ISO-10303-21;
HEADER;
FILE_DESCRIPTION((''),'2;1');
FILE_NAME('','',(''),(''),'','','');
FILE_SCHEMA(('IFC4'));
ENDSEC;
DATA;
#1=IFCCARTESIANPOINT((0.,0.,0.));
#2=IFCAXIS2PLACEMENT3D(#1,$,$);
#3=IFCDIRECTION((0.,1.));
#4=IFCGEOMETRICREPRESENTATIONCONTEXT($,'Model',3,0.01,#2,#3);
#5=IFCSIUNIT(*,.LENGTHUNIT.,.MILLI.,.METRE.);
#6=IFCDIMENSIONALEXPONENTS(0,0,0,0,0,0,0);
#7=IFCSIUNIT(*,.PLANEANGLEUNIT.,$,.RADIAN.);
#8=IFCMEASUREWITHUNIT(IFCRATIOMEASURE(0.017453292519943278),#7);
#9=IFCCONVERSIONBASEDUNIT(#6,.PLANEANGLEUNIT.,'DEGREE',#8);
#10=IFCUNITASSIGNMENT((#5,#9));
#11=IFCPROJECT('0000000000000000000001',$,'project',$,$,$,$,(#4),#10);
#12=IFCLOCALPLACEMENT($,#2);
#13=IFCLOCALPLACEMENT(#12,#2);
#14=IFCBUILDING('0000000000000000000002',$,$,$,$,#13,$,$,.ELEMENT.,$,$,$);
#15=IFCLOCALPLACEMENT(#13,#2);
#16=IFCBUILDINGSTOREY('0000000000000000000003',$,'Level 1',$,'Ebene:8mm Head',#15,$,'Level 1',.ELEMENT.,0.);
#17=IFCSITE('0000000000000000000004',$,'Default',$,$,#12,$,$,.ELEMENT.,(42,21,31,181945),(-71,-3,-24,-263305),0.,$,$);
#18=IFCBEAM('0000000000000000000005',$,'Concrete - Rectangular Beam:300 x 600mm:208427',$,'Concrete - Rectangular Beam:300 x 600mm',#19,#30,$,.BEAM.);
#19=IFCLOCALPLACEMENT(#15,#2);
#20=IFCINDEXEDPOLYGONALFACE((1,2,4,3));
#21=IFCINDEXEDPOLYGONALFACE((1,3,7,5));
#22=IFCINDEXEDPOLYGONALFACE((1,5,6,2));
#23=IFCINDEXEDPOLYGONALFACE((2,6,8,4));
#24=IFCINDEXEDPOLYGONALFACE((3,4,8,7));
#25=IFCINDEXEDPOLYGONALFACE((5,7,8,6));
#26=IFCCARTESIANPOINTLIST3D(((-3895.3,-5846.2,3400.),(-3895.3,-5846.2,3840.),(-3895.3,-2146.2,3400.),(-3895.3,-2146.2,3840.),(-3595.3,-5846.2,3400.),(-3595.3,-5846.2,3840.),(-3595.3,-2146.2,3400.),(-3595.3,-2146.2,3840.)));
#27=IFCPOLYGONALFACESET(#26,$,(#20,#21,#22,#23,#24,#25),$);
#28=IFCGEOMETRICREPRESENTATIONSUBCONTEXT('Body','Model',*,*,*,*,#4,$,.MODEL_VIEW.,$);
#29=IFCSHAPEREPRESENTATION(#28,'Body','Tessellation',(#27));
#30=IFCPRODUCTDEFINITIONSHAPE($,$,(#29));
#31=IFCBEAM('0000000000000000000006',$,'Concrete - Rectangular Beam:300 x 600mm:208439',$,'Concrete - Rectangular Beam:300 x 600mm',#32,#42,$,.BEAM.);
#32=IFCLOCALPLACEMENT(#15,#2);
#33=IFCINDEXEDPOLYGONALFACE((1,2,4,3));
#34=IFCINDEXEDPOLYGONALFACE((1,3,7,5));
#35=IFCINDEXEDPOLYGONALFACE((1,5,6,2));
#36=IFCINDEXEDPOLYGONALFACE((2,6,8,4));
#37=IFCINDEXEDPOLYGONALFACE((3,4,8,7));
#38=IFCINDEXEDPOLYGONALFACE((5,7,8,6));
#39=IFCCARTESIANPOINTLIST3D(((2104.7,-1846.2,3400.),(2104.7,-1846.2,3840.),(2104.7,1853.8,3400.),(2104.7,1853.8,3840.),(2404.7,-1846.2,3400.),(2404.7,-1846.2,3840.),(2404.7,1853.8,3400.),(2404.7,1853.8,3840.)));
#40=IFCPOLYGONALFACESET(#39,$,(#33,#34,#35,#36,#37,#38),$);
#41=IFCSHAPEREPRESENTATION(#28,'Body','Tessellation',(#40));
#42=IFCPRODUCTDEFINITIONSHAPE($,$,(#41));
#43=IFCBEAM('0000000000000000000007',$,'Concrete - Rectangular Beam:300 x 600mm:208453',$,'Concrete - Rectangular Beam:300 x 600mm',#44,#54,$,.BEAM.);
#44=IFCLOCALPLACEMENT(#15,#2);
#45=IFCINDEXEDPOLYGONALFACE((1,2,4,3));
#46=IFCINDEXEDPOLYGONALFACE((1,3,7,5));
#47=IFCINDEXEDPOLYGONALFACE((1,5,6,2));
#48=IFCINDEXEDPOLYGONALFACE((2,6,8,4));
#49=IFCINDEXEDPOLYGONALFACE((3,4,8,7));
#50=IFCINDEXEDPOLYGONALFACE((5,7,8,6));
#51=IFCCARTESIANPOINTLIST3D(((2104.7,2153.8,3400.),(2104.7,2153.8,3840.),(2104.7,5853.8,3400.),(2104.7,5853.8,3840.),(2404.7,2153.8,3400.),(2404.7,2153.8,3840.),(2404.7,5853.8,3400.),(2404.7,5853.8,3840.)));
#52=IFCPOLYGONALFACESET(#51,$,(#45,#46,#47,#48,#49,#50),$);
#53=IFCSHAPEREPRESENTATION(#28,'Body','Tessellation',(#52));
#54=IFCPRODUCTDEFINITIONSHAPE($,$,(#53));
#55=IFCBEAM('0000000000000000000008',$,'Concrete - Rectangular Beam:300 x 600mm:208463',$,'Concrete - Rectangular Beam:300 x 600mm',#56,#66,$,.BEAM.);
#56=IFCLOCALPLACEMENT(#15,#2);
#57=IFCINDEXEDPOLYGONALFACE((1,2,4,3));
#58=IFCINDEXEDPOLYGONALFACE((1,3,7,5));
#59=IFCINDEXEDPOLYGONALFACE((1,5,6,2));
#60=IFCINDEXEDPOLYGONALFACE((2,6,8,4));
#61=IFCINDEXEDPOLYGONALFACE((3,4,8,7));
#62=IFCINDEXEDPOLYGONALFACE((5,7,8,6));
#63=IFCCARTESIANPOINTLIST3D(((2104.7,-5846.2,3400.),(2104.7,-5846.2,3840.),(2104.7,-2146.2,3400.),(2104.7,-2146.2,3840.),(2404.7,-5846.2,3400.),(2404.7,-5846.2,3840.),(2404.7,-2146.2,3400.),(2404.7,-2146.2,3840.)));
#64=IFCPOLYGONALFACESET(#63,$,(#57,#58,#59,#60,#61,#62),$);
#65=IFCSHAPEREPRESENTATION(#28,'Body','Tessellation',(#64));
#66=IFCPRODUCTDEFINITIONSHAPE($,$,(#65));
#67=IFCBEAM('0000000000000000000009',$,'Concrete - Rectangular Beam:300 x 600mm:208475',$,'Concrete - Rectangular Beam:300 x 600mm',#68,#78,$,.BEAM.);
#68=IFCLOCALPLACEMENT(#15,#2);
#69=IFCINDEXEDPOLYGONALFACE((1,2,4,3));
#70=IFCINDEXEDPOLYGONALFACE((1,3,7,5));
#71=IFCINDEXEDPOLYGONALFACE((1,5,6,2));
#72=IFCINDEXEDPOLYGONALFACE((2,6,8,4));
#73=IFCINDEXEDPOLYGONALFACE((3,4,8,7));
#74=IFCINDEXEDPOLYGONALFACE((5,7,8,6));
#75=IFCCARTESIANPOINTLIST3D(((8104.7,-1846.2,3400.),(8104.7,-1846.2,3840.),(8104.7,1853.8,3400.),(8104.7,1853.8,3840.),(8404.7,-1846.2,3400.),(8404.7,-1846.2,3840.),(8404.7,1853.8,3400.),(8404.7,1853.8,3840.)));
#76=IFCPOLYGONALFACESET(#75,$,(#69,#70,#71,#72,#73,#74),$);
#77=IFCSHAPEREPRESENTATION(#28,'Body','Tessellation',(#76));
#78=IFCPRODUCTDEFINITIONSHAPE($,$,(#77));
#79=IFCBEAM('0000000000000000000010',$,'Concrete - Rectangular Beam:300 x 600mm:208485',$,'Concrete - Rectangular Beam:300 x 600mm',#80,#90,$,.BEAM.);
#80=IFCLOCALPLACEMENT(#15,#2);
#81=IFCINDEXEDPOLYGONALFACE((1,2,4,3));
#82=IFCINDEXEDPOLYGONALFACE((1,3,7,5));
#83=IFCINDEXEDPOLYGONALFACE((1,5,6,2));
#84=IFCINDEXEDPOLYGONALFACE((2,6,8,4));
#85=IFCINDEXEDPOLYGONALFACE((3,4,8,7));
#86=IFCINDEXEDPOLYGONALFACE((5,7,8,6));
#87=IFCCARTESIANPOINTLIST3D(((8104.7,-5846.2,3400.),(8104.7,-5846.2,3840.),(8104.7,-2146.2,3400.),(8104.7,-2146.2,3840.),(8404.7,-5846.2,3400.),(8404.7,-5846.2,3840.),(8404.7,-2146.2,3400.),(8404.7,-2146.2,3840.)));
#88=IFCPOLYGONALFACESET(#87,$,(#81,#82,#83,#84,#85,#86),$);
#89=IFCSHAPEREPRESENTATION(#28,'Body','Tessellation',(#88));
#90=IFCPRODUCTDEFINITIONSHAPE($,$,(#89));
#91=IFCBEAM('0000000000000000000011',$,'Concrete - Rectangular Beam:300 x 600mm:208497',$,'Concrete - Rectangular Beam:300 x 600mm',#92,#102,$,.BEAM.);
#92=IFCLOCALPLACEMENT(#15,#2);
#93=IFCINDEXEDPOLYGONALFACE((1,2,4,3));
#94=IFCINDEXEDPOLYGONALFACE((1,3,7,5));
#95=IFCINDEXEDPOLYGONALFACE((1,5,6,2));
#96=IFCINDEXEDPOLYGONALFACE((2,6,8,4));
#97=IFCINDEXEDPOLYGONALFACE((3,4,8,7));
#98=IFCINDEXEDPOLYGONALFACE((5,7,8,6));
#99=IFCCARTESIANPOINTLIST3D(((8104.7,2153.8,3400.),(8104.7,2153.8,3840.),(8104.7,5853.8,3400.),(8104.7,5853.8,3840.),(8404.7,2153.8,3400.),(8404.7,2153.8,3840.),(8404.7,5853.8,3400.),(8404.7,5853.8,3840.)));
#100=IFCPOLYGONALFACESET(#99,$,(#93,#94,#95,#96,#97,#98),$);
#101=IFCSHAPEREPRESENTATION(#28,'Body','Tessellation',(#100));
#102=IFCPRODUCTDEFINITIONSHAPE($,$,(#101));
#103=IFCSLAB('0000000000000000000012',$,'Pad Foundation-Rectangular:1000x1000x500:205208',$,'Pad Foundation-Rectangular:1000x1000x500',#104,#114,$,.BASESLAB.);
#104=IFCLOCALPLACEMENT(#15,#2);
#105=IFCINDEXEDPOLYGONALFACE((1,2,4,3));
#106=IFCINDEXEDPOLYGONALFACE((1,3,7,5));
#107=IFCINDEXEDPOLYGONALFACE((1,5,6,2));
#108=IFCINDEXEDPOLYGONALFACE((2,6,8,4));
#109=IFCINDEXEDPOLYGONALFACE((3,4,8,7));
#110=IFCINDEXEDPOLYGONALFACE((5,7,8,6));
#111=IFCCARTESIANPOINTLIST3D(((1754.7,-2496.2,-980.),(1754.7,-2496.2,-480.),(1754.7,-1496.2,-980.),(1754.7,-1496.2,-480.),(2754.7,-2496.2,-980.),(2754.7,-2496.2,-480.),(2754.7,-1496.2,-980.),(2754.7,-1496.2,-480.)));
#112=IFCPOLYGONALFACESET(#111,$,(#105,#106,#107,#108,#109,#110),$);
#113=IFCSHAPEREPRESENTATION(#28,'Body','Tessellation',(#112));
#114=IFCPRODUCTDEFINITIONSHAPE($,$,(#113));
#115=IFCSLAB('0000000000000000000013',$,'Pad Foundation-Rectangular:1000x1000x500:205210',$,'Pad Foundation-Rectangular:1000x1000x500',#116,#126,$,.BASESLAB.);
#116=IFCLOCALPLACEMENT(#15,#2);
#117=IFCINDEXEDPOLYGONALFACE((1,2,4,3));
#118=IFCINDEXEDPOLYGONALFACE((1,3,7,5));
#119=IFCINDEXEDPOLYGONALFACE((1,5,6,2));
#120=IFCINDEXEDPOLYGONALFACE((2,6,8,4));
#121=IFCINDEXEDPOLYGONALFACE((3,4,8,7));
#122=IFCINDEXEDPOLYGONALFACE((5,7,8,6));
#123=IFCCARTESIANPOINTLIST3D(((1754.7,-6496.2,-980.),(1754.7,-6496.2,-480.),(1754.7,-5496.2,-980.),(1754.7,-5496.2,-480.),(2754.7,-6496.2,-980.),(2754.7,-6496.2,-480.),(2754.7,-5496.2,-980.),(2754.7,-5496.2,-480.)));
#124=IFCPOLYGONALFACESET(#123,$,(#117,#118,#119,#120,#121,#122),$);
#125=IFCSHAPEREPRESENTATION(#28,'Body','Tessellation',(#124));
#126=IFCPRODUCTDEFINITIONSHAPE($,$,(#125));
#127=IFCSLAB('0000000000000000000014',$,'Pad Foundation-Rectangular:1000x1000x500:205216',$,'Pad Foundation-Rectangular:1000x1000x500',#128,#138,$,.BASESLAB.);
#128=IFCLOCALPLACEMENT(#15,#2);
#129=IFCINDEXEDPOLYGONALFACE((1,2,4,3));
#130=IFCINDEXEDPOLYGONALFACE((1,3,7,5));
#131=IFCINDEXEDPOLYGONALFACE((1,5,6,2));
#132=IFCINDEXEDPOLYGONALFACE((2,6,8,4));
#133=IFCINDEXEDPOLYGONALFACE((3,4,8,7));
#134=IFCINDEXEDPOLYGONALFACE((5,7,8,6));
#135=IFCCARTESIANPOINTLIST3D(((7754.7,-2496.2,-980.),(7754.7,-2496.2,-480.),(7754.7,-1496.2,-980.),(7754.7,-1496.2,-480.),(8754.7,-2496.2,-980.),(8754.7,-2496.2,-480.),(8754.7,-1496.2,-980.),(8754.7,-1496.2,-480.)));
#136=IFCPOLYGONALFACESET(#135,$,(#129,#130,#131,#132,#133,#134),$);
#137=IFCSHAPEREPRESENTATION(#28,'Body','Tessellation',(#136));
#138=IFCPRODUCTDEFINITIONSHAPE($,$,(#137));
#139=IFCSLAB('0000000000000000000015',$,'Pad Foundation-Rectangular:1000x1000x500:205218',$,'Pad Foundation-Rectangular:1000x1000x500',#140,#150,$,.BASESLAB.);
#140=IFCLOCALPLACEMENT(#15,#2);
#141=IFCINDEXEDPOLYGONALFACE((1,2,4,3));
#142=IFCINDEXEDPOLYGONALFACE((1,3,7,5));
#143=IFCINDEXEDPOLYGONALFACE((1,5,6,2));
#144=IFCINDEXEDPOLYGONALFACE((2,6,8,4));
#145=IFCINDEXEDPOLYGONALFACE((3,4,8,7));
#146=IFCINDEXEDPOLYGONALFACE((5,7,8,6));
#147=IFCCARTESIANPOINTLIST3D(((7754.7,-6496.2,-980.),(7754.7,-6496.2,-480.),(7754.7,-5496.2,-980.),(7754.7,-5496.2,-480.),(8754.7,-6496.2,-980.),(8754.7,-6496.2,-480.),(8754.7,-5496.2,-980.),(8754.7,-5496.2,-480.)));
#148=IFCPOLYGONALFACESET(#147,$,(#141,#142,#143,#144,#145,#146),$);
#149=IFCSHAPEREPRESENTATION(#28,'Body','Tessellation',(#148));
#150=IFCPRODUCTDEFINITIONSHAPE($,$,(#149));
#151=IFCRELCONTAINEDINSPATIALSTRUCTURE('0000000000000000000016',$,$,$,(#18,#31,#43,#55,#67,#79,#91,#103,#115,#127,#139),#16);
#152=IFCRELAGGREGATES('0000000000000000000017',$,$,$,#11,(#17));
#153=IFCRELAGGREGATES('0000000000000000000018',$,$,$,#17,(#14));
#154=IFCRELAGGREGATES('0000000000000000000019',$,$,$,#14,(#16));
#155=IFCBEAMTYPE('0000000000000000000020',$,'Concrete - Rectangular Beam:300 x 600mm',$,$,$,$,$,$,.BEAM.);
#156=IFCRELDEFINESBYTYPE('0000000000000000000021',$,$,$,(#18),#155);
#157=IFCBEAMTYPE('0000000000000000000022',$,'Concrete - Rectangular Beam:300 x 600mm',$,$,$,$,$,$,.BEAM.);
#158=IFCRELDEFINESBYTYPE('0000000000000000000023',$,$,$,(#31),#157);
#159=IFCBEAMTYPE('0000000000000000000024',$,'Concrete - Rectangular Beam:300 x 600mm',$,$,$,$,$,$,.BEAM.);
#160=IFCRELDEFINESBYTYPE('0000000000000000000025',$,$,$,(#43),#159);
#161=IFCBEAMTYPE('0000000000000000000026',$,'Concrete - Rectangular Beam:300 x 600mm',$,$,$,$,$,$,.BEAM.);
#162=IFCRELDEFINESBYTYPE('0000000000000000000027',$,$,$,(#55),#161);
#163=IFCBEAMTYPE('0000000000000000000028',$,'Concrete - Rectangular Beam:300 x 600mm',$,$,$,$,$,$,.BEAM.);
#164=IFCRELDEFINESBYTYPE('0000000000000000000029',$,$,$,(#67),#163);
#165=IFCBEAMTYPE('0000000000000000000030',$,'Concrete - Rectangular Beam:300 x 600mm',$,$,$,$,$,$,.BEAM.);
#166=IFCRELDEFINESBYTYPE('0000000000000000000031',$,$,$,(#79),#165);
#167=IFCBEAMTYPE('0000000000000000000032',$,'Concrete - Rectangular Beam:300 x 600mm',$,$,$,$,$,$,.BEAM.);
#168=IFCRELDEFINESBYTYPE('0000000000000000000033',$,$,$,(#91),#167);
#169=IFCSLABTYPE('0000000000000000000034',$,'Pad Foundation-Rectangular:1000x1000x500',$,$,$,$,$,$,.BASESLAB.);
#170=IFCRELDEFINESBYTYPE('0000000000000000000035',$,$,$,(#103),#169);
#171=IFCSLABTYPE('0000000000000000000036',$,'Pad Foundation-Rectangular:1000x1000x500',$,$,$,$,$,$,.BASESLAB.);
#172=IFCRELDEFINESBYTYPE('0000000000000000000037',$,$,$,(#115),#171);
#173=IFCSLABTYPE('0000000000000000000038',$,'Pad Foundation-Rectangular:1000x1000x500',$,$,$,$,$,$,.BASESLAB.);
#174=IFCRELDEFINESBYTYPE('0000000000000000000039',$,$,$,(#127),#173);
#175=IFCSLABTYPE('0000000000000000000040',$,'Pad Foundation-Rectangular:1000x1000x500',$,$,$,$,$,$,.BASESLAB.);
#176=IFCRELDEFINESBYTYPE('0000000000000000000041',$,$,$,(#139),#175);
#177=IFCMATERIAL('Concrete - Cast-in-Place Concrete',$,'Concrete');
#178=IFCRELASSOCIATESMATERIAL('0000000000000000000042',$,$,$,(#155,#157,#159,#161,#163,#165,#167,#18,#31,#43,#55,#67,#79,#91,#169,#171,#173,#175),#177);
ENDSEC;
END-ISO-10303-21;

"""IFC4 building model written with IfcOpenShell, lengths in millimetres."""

from ifc_helpers import new_model, entity, si_unit, converted_unit, direction, frame, frame_2d, origin, origin_2d_with_axis, place, context, subcontext, project, spatial, polyline, segment, composite_curve, rectangle, outline, extrude, source, transform, mapped, material, material_profile, profile_set, profile_usage, type_object, type_shapes, element, save


model = new_model("IFC4")

# Units and contexts
model_context = context("Model", 3, precision=0.01, world=origin(), true_north=direction((0.0, 1.0)))
body_context = subcontext(model_context, "Body", "Model", "MODEL_VIEW")
ifc_project = project(units=[si_unit("LENGTHUNIT", "METRE", prefix="MILLI"), converted_unit("PLANEANGLEUNIT", "DEGREE", entity("IfcRatioMeasure", 0.017453292519943278), si_unit("PLANEANGLEUNIT", "RADIAN"), dimensions=[0, 0, 0, 0, 0, 0, 0])], contexts=[model_context])

# Site, building, storey
site_placement = place(None, origin())
site = spatial("IfcSite", under=ifc_project, at=site_placement, Name="Default", CompositionType="ELEMENT", RefLatitude=(42, 21, 31, 181945), RefLongitude=(-71, -3, -24, -263305), RefElevation=0.0)
building_placement = place(site_placement, origin())
building = spatial("IfcBuilding", under=site, at=building_placement, CompositionType="ELEMENT")
storey_placement = place(building_placement, origin())
storey = spatial("IfcBuildingStorey", under=building, at=storey_placement, Name="Level 1", ObjectType="Ebene:8mm Head", LongName="Level 1", CompositionType="ELEMENT", Elevation=0.0)

# Beams
ifc_material_1 = material(Name="Concrete - Cast-in-Place Concrete", Category="Concrete")
ifc_material_profile_1 = material_profile(ifc_material_1, outline(composite_curve([segment(polyline([(-150.0, -300.0, 0.0), (-150.0, 140.0, 0.0)]), True, "CONTINUOUS"), segment(polyline([(-150.0, 140.0, 0.0), (150.0, 140.0, 0.0)]), True, "CONTINUOUS"), segment(polyline([(150.0, 140.0, 0.0), (150.0, -300.0, 0.0)]), True, "CONTINUOUS"), segment(polyline([(150.0, -300.0, 0.0), (-150.0, -300.0, 0.0)]), True, "CONTINUOUS")], self_intersect=False), kind="CURVE"), Name="300 x 600mm")
ifc_material_profile_2 = material_profile(ifc_material_1, outline(composite_curve([segment(polyline([(1850.0, -150.0, -300.0), (1850.0, -150.0, 300.0)]), True, "CONTINUOUS"), segment(polyline([(1850.0, -150.0, 300.0), (-1850.0, -150.0, 300.0)]), True, "CONTINUOUS"), segment(polyline([(-1850.0, -150.0, 300.0), (-1850.0, -150.0, -300.0)]), True, "CONTINUOUS"), segment(polyline([(-1850.0, -150.0, -300.0), (1850.0, -150.0, -300.0)]), True, "CONTINUOUS")], self_intersect=False), kind="CURVE"), Name="300 x 600mm")
ifc_profile_set = profile_set([ifc_material_profile_1, ifc_material_profile_2], Name="300 x 600mm")
ifc_profile_usage_1 = profile_usage(ifc_profile_set, cardinal=8)
beam_type_1 = type_object("IfcBeamType", Name="Concrete - Rectangular Beam:300 x 600mm", PredefinedType="BEAM", material=ifc_profile_set)
shared_shape_1 = source(origin(), body_context, "Body", "SweptSolid", [
    extrude(rectangle(XDim=440.0, YDim=300.0, at=frame_2d((0.0, 0.0), x_axis=(0.0, 1.0))), frame((-3745.3, -2146.2, 3620.0), z_axis=(0.0, -1.0, 0.0), x_axis=(-1.0, 0.0, 0.0)), (0.0, 0.0, 1.0), 3700.0),
])
type_shapes(beam_type_1, [shared_shape_1])
beam_1_placement = place(storey_placement, origin())
element("IfcBeam", 1, at=beam_1_placement, inside=storey, type_object=beam_type_1, material=ifc_profile_usage_1, Name="Concrete - Rectangular Beam:300 x 600mm:208427", ObjectType="Concrete - Rectangular Beam:300 x 600mm", PredefinedType="BEAM", context=body_context, shape_type="MappedRepresentation", body=[
    mapped(shared_shape_1, transform((0.0, 0.0, 0.0), scale=1.0)),
])
ifc_profile_usage_2 = profile_usage(ifc_profile_set, cardinal=8)
beam_type_2 = type_object("IfcBeamType", Name="Concrete - Rectangular Beam:300 x 600mm", PredefinedType="BEAM", material=ifc_profile_set)
shared_shape_2 = source(origin(), body_context, "Body", "SweptSolid", [
    extrude(rectangle(XDim=440.0, YDim=300.0, at=frame_2d((0.0, 0.0), x_axis=(0.0, 1.0))), frame((2254.7, 1853.8, 3620.0), z_axis=(0.0, -1.0, 0.0), x_axis=(-1.0, 0.0, 0.0)), (0.0, 0.0, 1.0), 3700.0),
])
type_shapes(beam_type_2, [shared_shape_2])
beam_2_placement = place(storey_placement, origin())
element("IfcBeam", 2, at=beam_2_placement, inside=storey, type_object=beam_type_2, material=ifc_profile_usage_2, Name="Concrete - Rectangular Beam:300 x 600mm:208439", ObjectType="Concrete - Rectangular Beam:300 x 600mm", PredefinedType="BEAM", context=body_context, shape_type="MappedRepresentation", body=[
    mapped(shared_shape_2, transform((0.0, 0.0, 0.0), scale=1.0)),
])
ifc_profile_usage_3 = profile_usage(ifc_profile_set, cardinal=8)
beam_type_3 = type_object("IfcBeamType", Name="Concrete - Rectangular Beam:300 x 600mm", PredefinedType="BEAM", material=ifc_profile_set)
shared_shape_3 = source(origin(), body_context, "Body", "SweptSolid", [
    extrude(rectangle(XDim=440.0, YDim=300.0, at=frame_2d((0.0, 0.0), x_axis=(0.0, 1.0))), frame((2254.7, 5853.8, 3620.0), z_axis=(0.0, -1.0, 0.0), x_axis=(-1.0, 0.0, 0.0)), (0.0, 0.0, 1.0), 3700.0),
])
type_shapes(beam_type_3, [shared_shape_3])
beam_3_placement = place(storey_placement, origin())
element("IfcBeam", 3, at=beam_3_placement, inside=storey, type_object=beam_type_3, material=ifc_profile_usage_3, Name="Concrete - Rectangular Beam:300 x 600mm:208453", ObjectType="Concrete - Rectangular Beam:300 x 600mm", PredefinedType="BEAM", context=body_context, shape_type="MappedRepresentation", body=[
    mapped(shared_shape_3, transform((0.0, 0.0, 0.0), scale=1.0)),
])
ifc_profile_usage_4 = profile_usage(ifc_profile_set, cardinal=8)
beam_type_4 = type_object("IfcBeamType", Name="Concrete - Rectangular Beam:300 x 600mm", PredefinedType="BEAM", material=ifc_profile_set)
shared_shape_4 = source(origin(), body_context, "Body", "SweptSolid", [
    extrude(rectangle(XDim=440.0, YDim=300.0, at=frame_2d((0.0, 0.0), x_axis=(0.0, 1.0))), frame((2254.7, -2146.2, 3620.0), z_axis=(0.0, -1.0, 0.0), x_axis=(-1.0, 0.0, 0.0)), (0.0, 0.0, 1.0), 3700.0),
])
type_shapes(beam_type_4, [shared_shape_4])
beam_4_placement = place(storey_placement, origin())
element("IfcBeam", 4, at=beam_4_placement, inside=storey, type_object=beam_type_4, material=ifc_profile_usage_4, Name="Concrete - Rectangular Beam:300 x 600mm:208463", ObjectType="Concrete - Rectangular Beam:300 x 600mm", PredefinedType="BEAM", context=body_context, shape_type="MappedRepresentation", body=[
    mapped(shared_shape_4, transform((0.0, 0.0, 0.0), scale=1.0)),
])
ifc_profile_usage_5 = profile_usage(ifc_profile_set, cardinal=8)
beam_type_5 = type_object("IfcBeamType", Name="Concrete - Rectangular Beam:300 x 600mm", PredefinedType="BEAM", material=ifc_profile_set)
shared_shape_5 = source(origin(), body_context, "Body", "SweptSolid", [
    extrude(rectangle(XDim=440.0, YDim=300.0, at=frame_2d((0.0, 0.0), x_axis=(0.0, 1.0))), frame((8254.7, 1853.8, 3620.0), z_axis=(0.0, -1.0, 0.0), x_axis=(-1.0, 0.0, 0.0)), (0.0, 0.0, 1.0), 3700.0),
])
type_shapes(beam_type_5, [shared_shape_5])
beam_5_placement = place(storey_placement, origin())
element("IfcBeam", 5, at=beam_5_placement, inside=storey, type_object=beam_type_5, material=ifc_profile_usage_5, Name="Concrete - Rectangular Beam:300 x 600mm:208475", ObjectType="Concrete - Rectangular Beam:300 x 600mm", PredefinedType="BEAM", context=body_context, shape_type="MappedRepresentation", body=[
    mapped(shared_shape_5, transform((0.0, 0.0, 0.0), scale=1.0)),
])
ifc_profile_usage_6 = profile_usage(ifc_profile_set, cardinal=8)
beam_type_6 = type_object("IfcBeamType", Name="Concrete - Rectangular Beam:300 x 600mm", PredefinedType="BEAM", material=ifc_profile_set)
shared_shape_6 = source(origin(), body_context, "Body", "SweptSolid", [
    extrude(rectangle(XDim=440.0, YDim=300.0, at=frame_2d((0.0, 0.0), x_axis=(0.0, 1.0))), frame((8254.7, -2146.2, 3620.0), z_axis=(0.0, -1.0, 0.0), x_axis=(-1.0, 0.0, 0.0)), (0.0, 0.0, 1.0), 3700.0),
])
type_shapes(beam_type_6, [shared_shape_6])
beam_6_placement = place(storey_placement, origin())
element("IfcBeam", 6, at=beam_6_placement, inside=storey, type_object=beam_type_6, material=ifc_profile_usage_6, Name="Concrete - Rectangular Beam:300 x 600mm:208485", ObjectType="Concrete - Rectangular Beam:300 x 600mm", PredefinedType="BEAM", context=body_context, shape_type="MappedRepresentation", body=[
    mapped(shared_shape_6, transform((0.0, 0.0, 0.0), scale=1.0)),
])
ifc_profile_usage_7 = profile_usage(ifc_profile_set, cardinal=8)
beam_type_7 = type_object("IfcBeamType", Name="Concrete - Rectangular Beam:300 x 600mm", PredefinedType="BEAM", material=ifc_profile_set)
shared_shape_7 = source(origin(), body_context, "Body", "SweptSolid", [
    extrude(rectangle(XDim=440.0, YDim=300.0, at=frame_2d((0.0, 0.0), x_axis=(0.0, 1.0))), frame((8254.7, 5853.8, 3620.0), z_axis=(0.0, -1.0, 0.0), x_axis=(-1.0, 0.0, 0.0)), (0.0, 0.0, 1.0), 3700.0),
])
type_shapes(beam_type_7, [shared_shape_7])
beam_7_placement = place(storey_placement, origin())
element("IfcBeam", 7, at=beam_7_placement, inside=storey, type_object=beam_type_7, material=ifc_profile_usage_7, Name="Concrete - Rectangular Beam:300 x 600mm:208497", ObjectType="Concrete - Rectangular Beam:300 x 600mm", PredefinedType="BEAM", context=body_context, shape_type="MappedRepresentation", body=[
    mapped(shared_shape_7, transform((0.0, 0.0, 0.0), scale=1.0)),
])

# Slabs
slab_type_1 = type_object("IfcSlabType", Name="Pad Foundation-Rectangular:1000x1000x500", PredefinedType="BASESLAB", material=ifc_material_1)
slab_1_placement = place(storey_placement, frame((1754.7, -2496.2, -980.0)))
element("IfcSlab", 8, at=slab_1_placement, inside=storey, type_object=slab_type_1, Name="Pad Foundation-Rectangular:1000x1000x500:205208", ObjectType="Pad Foundation-Rectangular:1000x1000x500", PredefinedType="BASESLAB", context=body_context, shape_type="SweptSolid", body=[
    extrude(rectangle(XDim=1000.0, YDim=1000.0, at=origin_2d_with_axis()), frame((500.0, 500.0, 0.0), z_axis=(0.0, 0.0, 1.0), x_axis=(-1.0, 0.0, 0.0)), (0.0, 0.0, 1.0), 500.0),
])
slab_type_2 = type_object("IfcSlabType", Name="Pad Foundation-Rectangular:1000x1000x500", PredefinedType="BASESLAB", material=ifc_material_1)
slab_2_placement = place(storey_placement, frame((1754.7, -6496.2, -980.0)))
element("IfcSlab", 9, at=slab_2_placement, inside=storey, type_object=slab_type_2, Name="Pad Foundation-Rectangular:1000x1000x500:205210", ObjectType="Pad Foundation-Rectangular:1000x1000x500", PredefinedType="BASESLAB", context=body_context, shape_type="SweptSolid", body=[
    extrude(rectangle(XDim=1000.0, YDim=1000.0, at=frame_2d((0.0, 0.0), x_axis=(1.0, 0.0))), frame((500.0, 500.0, 0.0), z_axis=(0.0, 0.0, 1.0), x_axis=(-1.0, 0.0, 0.0)), (0.0, 0.0, 1.0), 500.0),
])
slab_type_3 = type_object("IfcSlabType", Name="Pad Foundation-Rectangular:1000x1000x500", PredefinedType="BASESLAB", material=ifc_material_1)
slab_3_placement = place(storey_placement, frame((7754.7, -2496.2, -980.0)))
element("IfcSlab", 10, at=slab_3_placement, inside=storey, type_object=slab_type_3, Name="Pad Foundation-Rectangular:1000x1000x500:205216", ObjectType="Pad Foundation-Rectangular:1000x1000x500", PredefinedType="BASESLAB", context=body_context, shape_type="SweptSolid", body=[
    extrude(rectangle(XDim=1000.0, YDim=1000.0, at=frame_2d((0.0, 0.0), x_axis=(1.0, 0.0))), frame((500.0, 500.0, 0.0), z_axis=(0.0, 0.0, 1.0), x_axis=(-1.0, 0.0, 0.0)), (0.0, 0.0, 1.0), 500.0),
])
slab_type_4 = type_object("IfcSlabType", Name="Pad Foundation-Rectangular:1000x1000x500", PredefinedType="BASESLAB", material=ifc_material_1)
slab_4_placement = place(storey_placement, frame((7754.7, -6496.2, -980.0)))
element("IfcSlab", 11, at=slab_4_placement, inside=storey, type_object=slab_type_4, Name="Pad Foundation-Rectangular:1000x1000x500:205218", ObjectType="Pad Foundation-Rectangular:1000x1000x500", PredefinedType="BASESLAB", context=body_context, shape_type="SweptSolid", body=[
    extrude(rectangle(XDim=1000.0, YDim=1000.0, at=frame_2d((0.0, 0.0), x_axis=(1.0, 0.0))), frame((500.0, 500.0, 0.0), z_axis=(0.0, 0.0, 1.0), x_axis=(-1.0, 0.0, 0.0)), (0.0, 0.0, 1.0), 500.0),
])

save(model, "model.ifc")
